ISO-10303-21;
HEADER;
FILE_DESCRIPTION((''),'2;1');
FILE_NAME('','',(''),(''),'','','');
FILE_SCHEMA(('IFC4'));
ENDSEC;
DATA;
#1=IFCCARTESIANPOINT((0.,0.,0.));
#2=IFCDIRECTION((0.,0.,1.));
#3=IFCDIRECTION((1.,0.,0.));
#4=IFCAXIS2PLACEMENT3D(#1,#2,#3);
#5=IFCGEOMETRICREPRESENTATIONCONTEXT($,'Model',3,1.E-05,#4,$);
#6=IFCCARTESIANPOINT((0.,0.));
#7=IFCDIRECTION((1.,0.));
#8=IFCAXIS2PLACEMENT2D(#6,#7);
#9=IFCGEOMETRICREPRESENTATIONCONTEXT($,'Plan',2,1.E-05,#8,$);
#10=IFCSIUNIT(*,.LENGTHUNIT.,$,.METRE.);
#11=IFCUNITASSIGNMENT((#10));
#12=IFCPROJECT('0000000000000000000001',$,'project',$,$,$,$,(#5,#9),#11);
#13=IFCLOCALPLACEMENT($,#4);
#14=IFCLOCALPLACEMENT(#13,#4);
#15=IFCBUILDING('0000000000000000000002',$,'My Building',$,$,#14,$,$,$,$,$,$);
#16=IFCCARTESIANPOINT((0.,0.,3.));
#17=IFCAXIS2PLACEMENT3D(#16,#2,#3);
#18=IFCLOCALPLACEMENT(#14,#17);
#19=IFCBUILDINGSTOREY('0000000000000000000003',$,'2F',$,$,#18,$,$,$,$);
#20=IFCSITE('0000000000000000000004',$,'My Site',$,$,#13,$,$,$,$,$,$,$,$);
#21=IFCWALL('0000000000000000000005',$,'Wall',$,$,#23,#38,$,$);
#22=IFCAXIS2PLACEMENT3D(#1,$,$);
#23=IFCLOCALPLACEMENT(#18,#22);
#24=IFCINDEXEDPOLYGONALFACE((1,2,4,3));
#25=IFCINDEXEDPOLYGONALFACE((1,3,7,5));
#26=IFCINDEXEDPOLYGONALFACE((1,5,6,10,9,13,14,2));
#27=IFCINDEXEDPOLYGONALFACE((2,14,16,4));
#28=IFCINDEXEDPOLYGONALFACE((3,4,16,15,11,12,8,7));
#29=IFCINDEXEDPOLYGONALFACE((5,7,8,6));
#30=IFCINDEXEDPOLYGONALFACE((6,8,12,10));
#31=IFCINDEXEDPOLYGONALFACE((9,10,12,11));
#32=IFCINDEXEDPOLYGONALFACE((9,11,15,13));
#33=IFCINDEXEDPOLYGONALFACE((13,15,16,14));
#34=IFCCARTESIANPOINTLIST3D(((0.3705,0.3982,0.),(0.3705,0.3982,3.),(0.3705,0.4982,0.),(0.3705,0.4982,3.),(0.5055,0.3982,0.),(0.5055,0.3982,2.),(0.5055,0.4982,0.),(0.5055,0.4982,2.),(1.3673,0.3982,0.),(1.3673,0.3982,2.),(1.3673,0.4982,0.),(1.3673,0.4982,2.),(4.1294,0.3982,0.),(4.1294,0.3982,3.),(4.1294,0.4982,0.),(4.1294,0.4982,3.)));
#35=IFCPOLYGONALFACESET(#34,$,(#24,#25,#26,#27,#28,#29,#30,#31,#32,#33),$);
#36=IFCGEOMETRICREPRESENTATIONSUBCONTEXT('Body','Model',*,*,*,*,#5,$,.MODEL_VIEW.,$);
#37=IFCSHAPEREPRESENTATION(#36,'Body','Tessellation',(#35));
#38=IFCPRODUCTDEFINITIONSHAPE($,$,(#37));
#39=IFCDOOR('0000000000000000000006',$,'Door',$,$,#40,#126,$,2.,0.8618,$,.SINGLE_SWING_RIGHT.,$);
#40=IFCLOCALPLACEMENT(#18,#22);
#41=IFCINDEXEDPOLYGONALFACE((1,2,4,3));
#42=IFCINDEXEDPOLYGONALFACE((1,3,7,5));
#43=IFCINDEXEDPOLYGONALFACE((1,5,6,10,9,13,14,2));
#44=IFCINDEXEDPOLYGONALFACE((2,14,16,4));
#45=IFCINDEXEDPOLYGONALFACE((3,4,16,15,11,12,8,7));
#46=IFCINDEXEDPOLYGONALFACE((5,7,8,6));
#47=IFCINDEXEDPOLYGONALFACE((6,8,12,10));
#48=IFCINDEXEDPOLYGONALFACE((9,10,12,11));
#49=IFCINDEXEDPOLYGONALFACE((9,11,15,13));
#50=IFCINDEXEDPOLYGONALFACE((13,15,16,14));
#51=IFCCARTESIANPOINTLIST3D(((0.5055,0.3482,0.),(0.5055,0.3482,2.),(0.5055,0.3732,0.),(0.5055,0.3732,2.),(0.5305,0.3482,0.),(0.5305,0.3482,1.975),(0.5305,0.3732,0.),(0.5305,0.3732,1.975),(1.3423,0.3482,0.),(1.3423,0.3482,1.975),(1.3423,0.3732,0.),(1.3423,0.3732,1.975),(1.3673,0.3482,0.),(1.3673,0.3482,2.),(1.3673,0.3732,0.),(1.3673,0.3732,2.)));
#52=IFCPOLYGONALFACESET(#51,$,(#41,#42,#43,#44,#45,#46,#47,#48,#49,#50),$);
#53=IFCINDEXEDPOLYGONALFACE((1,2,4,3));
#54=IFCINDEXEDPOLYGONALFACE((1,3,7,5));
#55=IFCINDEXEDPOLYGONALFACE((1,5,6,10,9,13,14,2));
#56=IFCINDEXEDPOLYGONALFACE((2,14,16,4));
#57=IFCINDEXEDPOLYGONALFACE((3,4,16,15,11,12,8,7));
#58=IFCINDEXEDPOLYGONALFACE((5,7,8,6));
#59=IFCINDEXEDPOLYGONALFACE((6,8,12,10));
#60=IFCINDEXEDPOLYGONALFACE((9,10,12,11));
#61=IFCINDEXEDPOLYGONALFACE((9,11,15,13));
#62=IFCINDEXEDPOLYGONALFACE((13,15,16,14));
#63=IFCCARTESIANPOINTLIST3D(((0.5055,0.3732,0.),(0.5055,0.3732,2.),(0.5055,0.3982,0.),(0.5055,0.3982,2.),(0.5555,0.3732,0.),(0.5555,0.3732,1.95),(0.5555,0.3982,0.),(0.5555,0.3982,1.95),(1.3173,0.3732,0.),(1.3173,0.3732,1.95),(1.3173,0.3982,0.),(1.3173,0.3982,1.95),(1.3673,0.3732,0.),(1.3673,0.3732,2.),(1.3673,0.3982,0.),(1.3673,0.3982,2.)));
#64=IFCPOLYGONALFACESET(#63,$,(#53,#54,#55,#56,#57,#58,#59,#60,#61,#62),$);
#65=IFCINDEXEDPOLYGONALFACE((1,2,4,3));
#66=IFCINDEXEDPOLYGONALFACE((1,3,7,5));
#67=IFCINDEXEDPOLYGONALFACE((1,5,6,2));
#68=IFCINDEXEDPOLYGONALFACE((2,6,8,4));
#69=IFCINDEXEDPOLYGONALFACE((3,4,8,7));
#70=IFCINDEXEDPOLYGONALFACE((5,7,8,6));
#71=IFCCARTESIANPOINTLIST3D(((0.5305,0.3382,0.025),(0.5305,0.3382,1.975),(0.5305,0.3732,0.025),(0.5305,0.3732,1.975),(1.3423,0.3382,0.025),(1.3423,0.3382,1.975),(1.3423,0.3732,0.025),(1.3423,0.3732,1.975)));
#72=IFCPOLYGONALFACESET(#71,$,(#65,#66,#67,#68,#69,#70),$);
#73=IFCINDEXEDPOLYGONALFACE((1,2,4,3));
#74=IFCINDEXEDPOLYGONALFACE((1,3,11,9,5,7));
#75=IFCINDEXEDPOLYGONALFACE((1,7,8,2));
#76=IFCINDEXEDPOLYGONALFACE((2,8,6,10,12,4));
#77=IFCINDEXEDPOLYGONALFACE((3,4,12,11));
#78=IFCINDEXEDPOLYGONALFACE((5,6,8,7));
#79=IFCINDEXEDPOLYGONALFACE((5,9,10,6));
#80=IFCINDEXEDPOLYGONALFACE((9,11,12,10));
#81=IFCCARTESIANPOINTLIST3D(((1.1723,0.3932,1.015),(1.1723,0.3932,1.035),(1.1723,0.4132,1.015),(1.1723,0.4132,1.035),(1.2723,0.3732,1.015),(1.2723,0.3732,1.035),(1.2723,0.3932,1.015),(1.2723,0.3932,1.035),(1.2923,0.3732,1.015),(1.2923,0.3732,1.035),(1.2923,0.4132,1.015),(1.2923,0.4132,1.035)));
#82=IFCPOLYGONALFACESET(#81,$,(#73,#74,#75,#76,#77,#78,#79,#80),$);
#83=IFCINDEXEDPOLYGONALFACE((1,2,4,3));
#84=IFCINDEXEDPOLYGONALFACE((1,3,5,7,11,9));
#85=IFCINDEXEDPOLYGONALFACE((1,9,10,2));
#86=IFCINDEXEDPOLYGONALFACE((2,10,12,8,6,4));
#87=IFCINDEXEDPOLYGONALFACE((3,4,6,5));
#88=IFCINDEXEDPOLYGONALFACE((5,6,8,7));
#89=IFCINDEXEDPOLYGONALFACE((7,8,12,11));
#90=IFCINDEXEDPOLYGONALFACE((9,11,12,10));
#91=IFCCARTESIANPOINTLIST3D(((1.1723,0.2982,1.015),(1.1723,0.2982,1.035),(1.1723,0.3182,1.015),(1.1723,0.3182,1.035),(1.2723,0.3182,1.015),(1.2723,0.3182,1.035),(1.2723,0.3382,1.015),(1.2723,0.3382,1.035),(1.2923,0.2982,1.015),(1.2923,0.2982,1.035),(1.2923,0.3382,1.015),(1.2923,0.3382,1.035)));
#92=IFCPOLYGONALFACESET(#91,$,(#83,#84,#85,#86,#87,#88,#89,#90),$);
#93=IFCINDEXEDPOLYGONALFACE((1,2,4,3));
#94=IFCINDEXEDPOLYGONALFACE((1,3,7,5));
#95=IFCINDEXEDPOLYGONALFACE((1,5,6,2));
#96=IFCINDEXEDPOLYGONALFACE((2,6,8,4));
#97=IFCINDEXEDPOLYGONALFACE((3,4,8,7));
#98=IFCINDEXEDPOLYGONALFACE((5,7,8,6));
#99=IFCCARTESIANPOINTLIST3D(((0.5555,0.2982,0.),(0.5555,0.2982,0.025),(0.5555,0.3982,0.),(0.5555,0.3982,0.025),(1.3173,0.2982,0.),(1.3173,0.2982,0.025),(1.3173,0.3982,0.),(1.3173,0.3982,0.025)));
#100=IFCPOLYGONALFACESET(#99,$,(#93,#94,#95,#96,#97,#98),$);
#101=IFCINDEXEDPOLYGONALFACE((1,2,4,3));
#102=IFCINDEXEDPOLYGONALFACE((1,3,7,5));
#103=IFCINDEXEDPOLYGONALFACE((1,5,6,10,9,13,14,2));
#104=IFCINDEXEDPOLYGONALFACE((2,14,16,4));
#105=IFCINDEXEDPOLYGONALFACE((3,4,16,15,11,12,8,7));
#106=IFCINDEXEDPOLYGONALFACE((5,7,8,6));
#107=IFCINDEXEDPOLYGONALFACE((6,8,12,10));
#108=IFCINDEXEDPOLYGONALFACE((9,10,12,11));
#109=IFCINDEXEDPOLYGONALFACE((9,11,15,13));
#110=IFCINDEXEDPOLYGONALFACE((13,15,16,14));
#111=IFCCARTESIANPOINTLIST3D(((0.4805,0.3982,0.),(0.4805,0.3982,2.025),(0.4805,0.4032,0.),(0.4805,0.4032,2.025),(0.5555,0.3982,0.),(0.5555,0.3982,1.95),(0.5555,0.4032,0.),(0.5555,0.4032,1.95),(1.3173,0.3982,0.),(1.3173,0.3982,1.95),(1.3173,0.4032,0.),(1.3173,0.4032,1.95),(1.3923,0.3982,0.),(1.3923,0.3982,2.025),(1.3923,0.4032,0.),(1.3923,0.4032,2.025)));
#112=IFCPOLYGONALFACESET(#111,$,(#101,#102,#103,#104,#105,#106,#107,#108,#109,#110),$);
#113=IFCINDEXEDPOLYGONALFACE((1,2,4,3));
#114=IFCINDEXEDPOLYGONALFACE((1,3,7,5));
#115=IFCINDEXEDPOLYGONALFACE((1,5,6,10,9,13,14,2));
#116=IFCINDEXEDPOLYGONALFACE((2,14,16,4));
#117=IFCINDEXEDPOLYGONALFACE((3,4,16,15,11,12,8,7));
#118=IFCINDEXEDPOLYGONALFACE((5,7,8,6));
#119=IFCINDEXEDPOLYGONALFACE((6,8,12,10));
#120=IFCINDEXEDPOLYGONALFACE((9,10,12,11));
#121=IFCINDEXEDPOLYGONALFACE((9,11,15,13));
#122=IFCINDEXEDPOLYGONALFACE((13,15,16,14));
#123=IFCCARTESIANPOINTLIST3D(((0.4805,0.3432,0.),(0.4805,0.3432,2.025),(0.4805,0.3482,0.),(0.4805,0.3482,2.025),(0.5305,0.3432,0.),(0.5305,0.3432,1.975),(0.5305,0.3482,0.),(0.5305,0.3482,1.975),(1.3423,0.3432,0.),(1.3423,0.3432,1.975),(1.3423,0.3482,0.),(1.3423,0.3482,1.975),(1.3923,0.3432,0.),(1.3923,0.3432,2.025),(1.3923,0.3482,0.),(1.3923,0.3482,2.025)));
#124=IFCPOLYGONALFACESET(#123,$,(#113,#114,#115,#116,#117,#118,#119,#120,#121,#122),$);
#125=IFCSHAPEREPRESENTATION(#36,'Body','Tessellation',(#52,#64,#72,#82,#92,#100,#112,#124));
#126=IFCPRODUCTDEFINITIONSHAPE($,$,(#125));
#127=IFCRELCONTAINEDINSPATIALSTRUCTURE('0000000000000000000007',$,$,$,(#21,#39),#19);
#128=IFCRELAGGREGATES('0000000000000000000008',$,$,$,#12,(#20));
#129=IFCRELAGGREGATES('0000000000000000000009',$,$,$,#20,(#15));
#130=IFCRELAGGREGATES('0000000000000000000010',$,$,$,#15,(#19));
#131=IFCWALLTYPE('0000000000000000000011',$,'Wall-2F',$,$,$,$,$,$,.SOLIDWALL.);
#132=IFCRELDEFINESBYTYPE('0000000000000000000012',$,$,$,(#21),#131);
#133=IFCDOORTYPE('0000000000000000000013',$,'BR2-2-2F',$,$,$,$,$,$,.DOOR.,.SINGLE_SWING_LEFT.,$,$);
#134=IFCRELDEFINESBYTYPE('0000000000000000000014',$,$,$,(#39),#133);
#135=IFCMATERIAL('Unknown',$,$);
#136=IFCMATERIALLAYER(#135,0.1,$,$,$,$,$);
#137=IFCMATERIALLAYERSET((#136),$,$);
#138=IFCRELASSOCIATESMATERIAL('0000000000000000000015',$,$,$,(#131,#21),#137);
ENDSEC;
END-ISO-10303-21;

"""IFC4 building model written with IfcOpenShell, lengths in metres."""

from ifc_helpers import new_model, entity, si_unit, frame, origin_with_axes, origin_2d_with_axis, place, context, subcontext, project, spatial, line, indexed_curve, outline, extrude, shape, source, transform, mapped, material, layer, layer_set, layer_usage, type_object, type_shapes, element, fill, save


model = new_model("IFC4")

# Units and contexts
model_context = context("Model", 3, precision=1e-05, world=origin_with_axes())
plan_context = context("Plan", 2, precision=1e-05, world=origin_2d_with_axis())
body_context_1 = subcontext(model_context, "Body", "Model", "MODEL_VIEW")
body_context_2 = subcontext(plan_context, "Body", "Plan", "PLAN_VIEW")
ifc_project = project(units=[si_unit("LENGTHUNIT", "METRE")], contexts=[model_context, plan_context])

# Site, building, storey
site_placement = place(None, origin_with_axes())
site = spatial("IfcSite", under=ifc_project, at=site_placement, Name="My Site")
building_placement = place(site_placement, origin_with_axes())
building = spatial("IfcBuilding", under=site, at=building_placement, Name="My Building")
storey_placement = place(building_placement, frame((0.0, 0.0, 3.0), z_axis=(0.0, 0.0, 1.0), x_axis=(1.0, 0.0, 0.0)))
storey = spatial("IfcBuildingStorey", under=building, at=storey_placement, Name="2F")

# Shared definitions
ifc_material = material(Name="Unknown")

# Shared definitions
ifc_layer_1 = layer(ifc_material, 0.1)
ifc_layer_set_1 = layer_set([ifc_layer_1])
wall_type = type_object("IfcWallType", Name="Wall-2F", PredefinedType="SOLIDWALL", material=ifc_layer_set_1)

# Wall, opening, door
ifc_layer_usage_1 = layer_usage(ifc_layer_set_1, "AXIS2", "NEGATIVE", 0.0)
wall_1_placement = place(storey_placement, frame((0.3705, 0.4982, 0.0), z_axis=(0.0, 0.0, 1.0), x_axis=(1.0, 0.0, 0.0)))
wall_1 = element("IfcWall", 1, at=wall_1_placement, inside=storey, type_object=wall_type, material=ifc_layer_usage_1, Name="Wall", context=body_context_1, shape_type="SweptSolid", body=[
    extrude(outline(indexed_curve([(0.0, -0.1), (0.0, 0.0), (3.7589, 0.0), (3.7589, -0.1)], segments=[line(1, 2, 3, 4, 1)])), origin_with_axes(), (0.0, 0.0, 1.0), 3.0),
])
shared_shape_1 = source(origin_with_axes(), body_context_1, "Body", "SweptSolid", [
    extrude(outline(indexed_curve([(0.0, 0.0), (0.8618, 0.0), (0.8618, 2.0), (0.0, 2.0)], segments=[line(1, 2, 3, 4, 1)])), frame((0.0, -0.6, 0.0), z_axis=(0.0, -1.0, 0.0), x_axis=(1.0, 0.0, 0.0)), (0.0, 0.0, -1.0), 1.2),
])
opening_1_placement = place(wall_1_placement, frame((0.9968, -0.1, 0.0), z_axis=(0.0, 0.0, 1.0), x_axis=(-1.0, 0.0, 0.0)))
opening_1 = element("IfcOpeningElement", 2, at=opening_1_placement, cuts=wall_1, PredefinedType="OPENING", context=body_context_1, shape_type="MappedRepresentation", body=[
    mapped(shared_shape_1, transform((0.0, 0.0, 0.0), x_axis=(1.0, 0.0, 0.0), y_axis=(0.0, 1.0, 0.0), z_axis=(0.0, 0.0, 1.0), scale=1.0)),
])
door_type_1 = type_object("IfcDoorType", Name="BR2-2-2F", OperationType="SINGLE_SWING_LEFT", PredefinedType="DOOR")
shared_shape_2 = source(origin_with_axes(), body_context_1, "Body", "SweptSolid", [
    extrude(outline(indexed_curve([(0.0, 0.0), (0.0, 2.0), (0.8618, 2.0), (0.8618, 0.0), (0.8368, 0.0), (0.8368, 1.975), (0.025, 1.975), (0.025, 0.0)], segments=[line(1, 2, 3, 4, 5, 6, 7, 8, 1)])), frame((0.0, 0.025, 0.0), z_axis=(0.0, -1.0, 0.0), x_axis=(1.0, 0.0, 0.0)), (0.0, 0.0, -1.0), 0.025),
    extrude(outline(indexed_curve([(0.0, 0.0), (0.0, 2.0), (0.8618, 2.0), (0.8618, 0.0), (0.8118, 0.0), (0.8118, 1.95), (0.05, 1.95), (0.05, 0.0)], segments=[line(1, 2, 3, 4, 5, 6, 7, 8, 1)])), frame((0.0, 0.0, 0.0), z_axis=(0.0, -1.0, 0.0), x_axis=(1.0, 0.0, 0.0)), (0.0, 0.0, -1.0), 0.025),
    extrude(outline(indexed_curve([(0.0, 0.0), (0.8118, 0.0), (0.8118, 0.035), (0.0, 0.035)], segments=[line(1, 2, 3, 4, 1)])), frame((0.025, 0.025, 0.025), z_axis=(0.0, 0.0, 1.0), x_axis=(1.0, 0.0, 0.0)), (0.0, 0.0, 1.0), 1.95),
    extrude(outline(indexed_curve([(0.0, 0.0), (0.0, -0.04), (0.12, -0.04), (0.12, -0.02), (0.02, -0.02), (0.02, 0.0)], segments=[line(1, 2, 3, 4, 5, 6, 1)])), frame((0.075, 0.025, 1.015), z_axis=(0.0, 0.0, 1.0), x_axis=(1.0, 0.0, 0.0)), (0.0, 0.0, 1.0), 0.02),
    extrude(outline(indexed_curve([(0.0, 0.0), (0.0, 0.04), (0.12, 0.04), (0.12, 0.02), (0.02, 0.02), (0.02, 0.0)], segments=[line(1, 2, 3, 4, 5, 6, 1)])), frame((0.075, 0.06, 1.015), z_axis=(0.0, 0.0, 1.0), x_axis=(1.0, 0.0, 0.0)), (0.0, 0.0, 1.0), 0.02),
    extrude(outline(indexed_curve([(0.0, 0.0), (0.7618, 0.0), (0.7618, 0.1), (0.0, 0.1)], segments=[line(1, 2, 3, 4, 1)])), frame((0.05, 0.0, 0.0), z_axis=(0.0, 0.0, 1.0), x_axis=(1.0, 0.0, 0.0)), (0.0, 0.0, 1.0), 0.025),
    extrude(outline(indexed_curve([(0.0, 0.0), (0.0, 2.025), (0.9118, 2.025), (0.9118, 0.0), (0.8368, 0.0), (0.8368, 1.95), (0.075, 1.95), (0.075, 0.0)], segments=[line(1, 2, 3, 4, 5, 6, 7, 8, 1)])), frame((-0.025, -0.005, 0.0), z_axis=(0.0, -1.0, 0.0), x_axis=(1.0, 0.0, 0.0)), (0.0, 0.0, -1.0), 0.005),
    extrude(outline(indexed_curve([(0.0, 0.0), (0.0, 2.025), (0.9118, 2.025), (0.9118, 0.0), (0.8618, 0.0), (0.8618, 1.975), (0.05, 1.975), (0.05, 0.0)], segments=[line(1, 2, 3, 4, 5, 6, 7, 8, 1)])), frame((-0.025, 0.05, 0.0), z_axis=(0.0, -1.0, 0.0), x_axis=(1.0, 0.0, 0.0)), (0.0, 0.0, -1.0), 0.005),
])
shared_shape_3 = source(origin_with_axes(), body_context_2, "Body", "Curve2D", [
    entity("IfcIndexedPolyCurve", entity("IfcCartesianPointList2D", [[0.0, 0.0], [0.0, 0.05], [0.025, 0.05], [0.025, 0.025], [0.05, 0.025], [0.05, 0.0]]), [entity("IfcLineIndex", [1, 2, 3, 4, 5, 6, 1])]),
    entity("IfcIndexedPolyCurve", entity("IfcCartesianPointList2D", [[0.8618, 0.0], [0.8618, 0.05], [0.8368, 0.05], [0.8368, 0.025], [0.8118, 0.025], [0.8118, 0.0]]), [entity("IfcLineIndex", [1, 2, 3, 4, 5, 6, 1])]),
    entity("IfcTrimmedCurve", entity("IfcEllipse", entity("IfcAxis2Placement2D", entity("IfcCartesianPoint", [0.8018, 0.05]), entity("IfcDirection", [1.0, 0.0])), 0.7768, 0.8118), [entity("IfcCartesianPoint", [0.8018, 0.8618])], [entity("IfcCartesianPoint", [0.025, 0.05])], True, "CARTESIAN"),
    entity("IfcIndexedPolyCurve", entity("IfcCartesianPointList2D", [[0.8368, 0.05], [0.8018, 0.05], [0.8018, 0.8618], [0.8368, 0.8618]]), [entity("IfcLineIndex", [1, 2, 3, 4, 1])]),
])
type_shapes(door_type_1, [shared_shape_2, shared_shape_3])
door_1_placement = place(opening_1_placement, frame((0.0, 0.0, 0.0), z_axis=(0.0, 0.0, 1.0), x_axis=(1.0, 0.0, 0.0)))
door_1 = element("IfcDoor", 3, at=door_1_placement, inside=storey, type_object=door_type_1, Name="Door", OperationType="SINGLE_SWING_RIGHT", OverallHeight=2.0, OverallWidth=0.8618, shapes=[
    shape(body_context_1, "Body", "MappedRepresentation", [mapped(shared_shape_2, transform((0.0, 0.0, 0.0), x_axis=(1.0, 0.0, 0.0), y_axis=(0.0, 1.0, 0.0), z_axis=(0.0, 0.0, 1.0), scale=1.0))]),
    shape(body_context_2, "Body", "MappedRepresentation", [mapped(shared_shape_3, transform((0.0, 0.0, 0.0), x_axis=(1.0, 0.0, 0.0), y_axis=(0.0, 1.0, 0.0), z_axis=(0.0, 0.0, 1.0), scale=1.0))]),
])
fill(opening_1, door_1)

save(model, "model.ifc")
